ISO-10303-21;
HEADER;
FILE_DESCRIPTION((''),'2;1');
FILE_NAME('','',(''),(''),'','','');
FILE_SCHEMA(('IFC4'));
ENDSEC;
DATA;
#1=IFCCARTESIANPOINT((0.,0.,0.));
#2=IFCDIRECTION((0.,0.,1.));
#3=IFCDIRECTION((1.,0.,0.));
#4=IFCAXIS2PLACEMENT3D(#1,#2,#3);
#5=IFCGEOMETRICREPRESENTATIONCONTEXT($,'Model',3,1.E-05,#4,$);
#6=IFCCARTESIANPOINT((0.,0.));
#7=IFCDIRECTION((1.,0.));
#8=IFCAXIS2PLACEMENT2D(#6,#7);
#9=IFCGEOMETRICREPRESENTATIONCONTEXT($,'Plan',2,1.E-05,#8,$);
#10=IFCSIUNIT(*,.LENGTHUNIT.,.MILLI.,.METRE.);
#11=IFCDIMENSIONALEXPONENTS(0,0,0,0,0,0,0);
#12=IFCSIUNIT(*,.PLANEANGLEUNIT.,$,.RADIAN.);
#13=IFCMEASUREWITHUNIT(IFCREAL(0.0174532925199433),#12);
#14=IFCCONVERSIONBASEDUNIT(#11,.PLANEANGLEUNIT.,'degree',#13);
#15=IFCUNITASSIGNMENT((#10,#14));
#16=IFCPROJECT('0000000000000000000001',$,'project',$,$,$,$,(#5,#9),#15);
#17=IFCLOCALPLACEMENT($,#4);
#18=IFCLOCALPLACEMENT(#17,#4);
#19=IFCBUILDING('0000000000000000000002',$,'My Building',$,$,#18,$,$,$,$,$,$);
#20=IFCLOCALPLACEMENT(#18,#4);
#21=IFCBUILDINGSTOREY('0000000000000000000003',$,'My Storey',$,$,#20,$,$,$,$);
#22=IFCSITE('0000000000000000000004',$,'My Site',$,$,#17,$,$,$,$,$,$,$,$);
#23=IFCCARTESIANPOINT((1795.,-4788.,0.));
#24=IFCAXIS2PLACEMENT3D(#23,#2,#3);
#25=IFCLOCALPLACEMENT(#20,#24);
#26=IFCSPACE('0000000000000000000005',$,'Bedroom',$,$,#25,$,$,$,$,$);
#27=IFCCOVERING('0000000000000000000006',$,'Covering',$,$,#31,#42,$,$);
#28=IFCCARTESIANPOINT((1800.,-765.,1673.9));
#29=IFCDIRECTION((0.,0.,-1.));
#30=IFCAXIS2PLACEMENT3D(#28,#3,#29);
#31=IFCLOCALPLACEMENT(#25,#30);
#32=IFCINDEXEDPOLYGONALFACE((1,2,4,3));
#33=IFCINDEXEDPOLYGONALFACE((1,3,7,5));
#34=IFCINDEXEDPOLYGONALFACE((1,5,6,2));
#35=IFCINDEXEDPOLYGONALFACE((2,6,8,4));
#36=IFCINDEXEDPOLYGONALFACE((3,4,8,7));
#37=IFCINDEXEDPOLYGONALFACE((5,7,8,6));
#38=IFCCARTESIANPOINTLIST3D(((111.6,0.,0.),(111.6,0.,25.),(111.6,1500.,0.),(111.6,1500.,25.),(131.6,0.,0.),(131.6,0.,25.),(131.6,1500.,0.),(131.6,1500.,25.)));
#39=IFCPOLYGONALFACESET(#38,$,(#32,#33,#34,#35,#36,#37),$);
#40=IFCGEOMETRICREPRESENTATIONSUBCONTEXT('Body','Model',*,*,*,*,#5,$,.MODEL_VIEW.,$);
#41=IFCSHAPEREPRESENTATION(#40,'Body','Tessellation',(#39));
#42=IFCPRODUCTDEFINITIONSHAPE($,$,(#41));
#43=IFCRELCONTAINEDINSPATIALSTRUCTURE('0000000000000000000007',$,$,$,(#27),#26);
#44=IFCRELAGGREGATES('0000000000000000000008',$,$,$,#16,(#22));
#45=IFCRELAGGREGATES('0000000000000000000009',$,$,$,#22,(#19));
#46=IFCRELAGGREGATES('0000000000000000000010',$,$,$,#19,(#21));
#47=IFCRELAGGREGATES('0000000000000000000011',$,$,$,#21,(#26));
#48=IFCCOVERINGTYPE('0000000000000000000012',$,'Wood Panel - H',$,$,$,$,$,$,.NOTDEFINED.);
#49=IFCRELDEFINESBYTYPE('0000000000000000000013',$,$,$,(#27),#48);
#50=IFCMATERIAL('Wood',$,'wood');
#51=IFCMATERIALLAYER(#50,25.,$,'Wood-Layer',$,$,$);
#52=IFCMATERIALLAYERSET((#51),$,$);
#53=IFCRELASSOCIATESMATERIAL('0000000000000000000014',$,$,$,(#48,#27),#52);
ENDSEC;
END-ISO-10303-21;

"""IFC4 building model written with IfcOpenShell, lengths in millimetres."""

from ifc_helpers import new_model, entity, si_unit, converted_unit, frame, origin_with_axes, origin_2d_with_axis, place, context, subcontext, project, spatial, line, indexed_curve, outline, extrude, material, layer, layer_set, layer_usage, type_object, element, save


model = new_model("IFC4")

# Units and contexts
model_context = context("Model", 3, precision=1e-05, world=origin_with_axes())
plan_context = context("Plan", 2, precision=1e-05, world=origin_2d_with_axis())
body_context_1 = subcontext(model_context, "Body", "Model", "MODEL_VIEW")
ifc_project = project(units=[si_unit("LENGTHUNIT", "METRE", prefix="MILLI"), converted_unit("PLANEANGLEUNIT", "degree", entity("IfcReal", 0.0174532925199433), si_unit("PLANEANGLEUNIT", "RADIAN"), dimensions=[0, 0, 0, 0, 0, 0, 0])], contexts=[model_context, plan_context])

# Site, building, storey
site_placement = place(None, origin_with_axes())
site = spatial("IfcSite", under=ifc_project, at=site_placement, Name="My Site")
building_placement = place(site_placement, origin_with_axes())
building = spatial("IfcBuilding", under=site, at=building_placement, Name="My Building")
storey_placement = place(building_placement, origin_with_axes())
storey = spatial("IfcBuildingStorey", under=building, at=storey_placement, Name="My Storey")

# Shared definitions
space_placement = place(storey_placement, frame((1795.0, -4788.0, 0.0), z_axis=(0.0, 0.0, 1.0), x_axis=(1.0, 0.0, 0.0)))
space = spatial("IfcSpace", under=storey, at=space_placement, Name="Bedroom")

# Covering
ifc_material_1 = material(Name="Wood", Category="wood")
ifc_layer_1 = layer(ifc_material_1, 25.0, Name="Wood-Layer")
ifc_layer_set_1 = layer_set([ifc_layer_1])
covering_type_1 = type_object("IfcCoveringType", Name="Wood Panel - H", PredefinedType="NOTDEFINED", material=ifc_layer_set_1)
ifc_layer_usage_1 = layer_usage(ifc_layer_set_1, "AXIS3", "POSITIVE", 0.0)
covering_1_placement = place(space_placement, frame((1800.0, -765.0, 1673.9), z_axis=(1.0, 0.0, 0.0), x_axis=(0.0, 0.0, -1.0)))
element("IfcCovering", 1, at=covering_1_placement, inside=space, type_object=covering_type_1, material=ifc_layer_usage_1, Name="Covering", context=body_context_1, shape_type="SweptSolid", body=[
    extrude(outline(indexed_curve([(131.6, 1500.0), (111.6, 1500.0), (111.6, 0.0), (131.6, 0.0)], segments=[line(3, 2), line(2, 1), line(1, 4), line(4, 3)], self_intersect=False)), None, (0.0, 0.0, 1.0), 25.0),
])

save(model, "model.ifc")
